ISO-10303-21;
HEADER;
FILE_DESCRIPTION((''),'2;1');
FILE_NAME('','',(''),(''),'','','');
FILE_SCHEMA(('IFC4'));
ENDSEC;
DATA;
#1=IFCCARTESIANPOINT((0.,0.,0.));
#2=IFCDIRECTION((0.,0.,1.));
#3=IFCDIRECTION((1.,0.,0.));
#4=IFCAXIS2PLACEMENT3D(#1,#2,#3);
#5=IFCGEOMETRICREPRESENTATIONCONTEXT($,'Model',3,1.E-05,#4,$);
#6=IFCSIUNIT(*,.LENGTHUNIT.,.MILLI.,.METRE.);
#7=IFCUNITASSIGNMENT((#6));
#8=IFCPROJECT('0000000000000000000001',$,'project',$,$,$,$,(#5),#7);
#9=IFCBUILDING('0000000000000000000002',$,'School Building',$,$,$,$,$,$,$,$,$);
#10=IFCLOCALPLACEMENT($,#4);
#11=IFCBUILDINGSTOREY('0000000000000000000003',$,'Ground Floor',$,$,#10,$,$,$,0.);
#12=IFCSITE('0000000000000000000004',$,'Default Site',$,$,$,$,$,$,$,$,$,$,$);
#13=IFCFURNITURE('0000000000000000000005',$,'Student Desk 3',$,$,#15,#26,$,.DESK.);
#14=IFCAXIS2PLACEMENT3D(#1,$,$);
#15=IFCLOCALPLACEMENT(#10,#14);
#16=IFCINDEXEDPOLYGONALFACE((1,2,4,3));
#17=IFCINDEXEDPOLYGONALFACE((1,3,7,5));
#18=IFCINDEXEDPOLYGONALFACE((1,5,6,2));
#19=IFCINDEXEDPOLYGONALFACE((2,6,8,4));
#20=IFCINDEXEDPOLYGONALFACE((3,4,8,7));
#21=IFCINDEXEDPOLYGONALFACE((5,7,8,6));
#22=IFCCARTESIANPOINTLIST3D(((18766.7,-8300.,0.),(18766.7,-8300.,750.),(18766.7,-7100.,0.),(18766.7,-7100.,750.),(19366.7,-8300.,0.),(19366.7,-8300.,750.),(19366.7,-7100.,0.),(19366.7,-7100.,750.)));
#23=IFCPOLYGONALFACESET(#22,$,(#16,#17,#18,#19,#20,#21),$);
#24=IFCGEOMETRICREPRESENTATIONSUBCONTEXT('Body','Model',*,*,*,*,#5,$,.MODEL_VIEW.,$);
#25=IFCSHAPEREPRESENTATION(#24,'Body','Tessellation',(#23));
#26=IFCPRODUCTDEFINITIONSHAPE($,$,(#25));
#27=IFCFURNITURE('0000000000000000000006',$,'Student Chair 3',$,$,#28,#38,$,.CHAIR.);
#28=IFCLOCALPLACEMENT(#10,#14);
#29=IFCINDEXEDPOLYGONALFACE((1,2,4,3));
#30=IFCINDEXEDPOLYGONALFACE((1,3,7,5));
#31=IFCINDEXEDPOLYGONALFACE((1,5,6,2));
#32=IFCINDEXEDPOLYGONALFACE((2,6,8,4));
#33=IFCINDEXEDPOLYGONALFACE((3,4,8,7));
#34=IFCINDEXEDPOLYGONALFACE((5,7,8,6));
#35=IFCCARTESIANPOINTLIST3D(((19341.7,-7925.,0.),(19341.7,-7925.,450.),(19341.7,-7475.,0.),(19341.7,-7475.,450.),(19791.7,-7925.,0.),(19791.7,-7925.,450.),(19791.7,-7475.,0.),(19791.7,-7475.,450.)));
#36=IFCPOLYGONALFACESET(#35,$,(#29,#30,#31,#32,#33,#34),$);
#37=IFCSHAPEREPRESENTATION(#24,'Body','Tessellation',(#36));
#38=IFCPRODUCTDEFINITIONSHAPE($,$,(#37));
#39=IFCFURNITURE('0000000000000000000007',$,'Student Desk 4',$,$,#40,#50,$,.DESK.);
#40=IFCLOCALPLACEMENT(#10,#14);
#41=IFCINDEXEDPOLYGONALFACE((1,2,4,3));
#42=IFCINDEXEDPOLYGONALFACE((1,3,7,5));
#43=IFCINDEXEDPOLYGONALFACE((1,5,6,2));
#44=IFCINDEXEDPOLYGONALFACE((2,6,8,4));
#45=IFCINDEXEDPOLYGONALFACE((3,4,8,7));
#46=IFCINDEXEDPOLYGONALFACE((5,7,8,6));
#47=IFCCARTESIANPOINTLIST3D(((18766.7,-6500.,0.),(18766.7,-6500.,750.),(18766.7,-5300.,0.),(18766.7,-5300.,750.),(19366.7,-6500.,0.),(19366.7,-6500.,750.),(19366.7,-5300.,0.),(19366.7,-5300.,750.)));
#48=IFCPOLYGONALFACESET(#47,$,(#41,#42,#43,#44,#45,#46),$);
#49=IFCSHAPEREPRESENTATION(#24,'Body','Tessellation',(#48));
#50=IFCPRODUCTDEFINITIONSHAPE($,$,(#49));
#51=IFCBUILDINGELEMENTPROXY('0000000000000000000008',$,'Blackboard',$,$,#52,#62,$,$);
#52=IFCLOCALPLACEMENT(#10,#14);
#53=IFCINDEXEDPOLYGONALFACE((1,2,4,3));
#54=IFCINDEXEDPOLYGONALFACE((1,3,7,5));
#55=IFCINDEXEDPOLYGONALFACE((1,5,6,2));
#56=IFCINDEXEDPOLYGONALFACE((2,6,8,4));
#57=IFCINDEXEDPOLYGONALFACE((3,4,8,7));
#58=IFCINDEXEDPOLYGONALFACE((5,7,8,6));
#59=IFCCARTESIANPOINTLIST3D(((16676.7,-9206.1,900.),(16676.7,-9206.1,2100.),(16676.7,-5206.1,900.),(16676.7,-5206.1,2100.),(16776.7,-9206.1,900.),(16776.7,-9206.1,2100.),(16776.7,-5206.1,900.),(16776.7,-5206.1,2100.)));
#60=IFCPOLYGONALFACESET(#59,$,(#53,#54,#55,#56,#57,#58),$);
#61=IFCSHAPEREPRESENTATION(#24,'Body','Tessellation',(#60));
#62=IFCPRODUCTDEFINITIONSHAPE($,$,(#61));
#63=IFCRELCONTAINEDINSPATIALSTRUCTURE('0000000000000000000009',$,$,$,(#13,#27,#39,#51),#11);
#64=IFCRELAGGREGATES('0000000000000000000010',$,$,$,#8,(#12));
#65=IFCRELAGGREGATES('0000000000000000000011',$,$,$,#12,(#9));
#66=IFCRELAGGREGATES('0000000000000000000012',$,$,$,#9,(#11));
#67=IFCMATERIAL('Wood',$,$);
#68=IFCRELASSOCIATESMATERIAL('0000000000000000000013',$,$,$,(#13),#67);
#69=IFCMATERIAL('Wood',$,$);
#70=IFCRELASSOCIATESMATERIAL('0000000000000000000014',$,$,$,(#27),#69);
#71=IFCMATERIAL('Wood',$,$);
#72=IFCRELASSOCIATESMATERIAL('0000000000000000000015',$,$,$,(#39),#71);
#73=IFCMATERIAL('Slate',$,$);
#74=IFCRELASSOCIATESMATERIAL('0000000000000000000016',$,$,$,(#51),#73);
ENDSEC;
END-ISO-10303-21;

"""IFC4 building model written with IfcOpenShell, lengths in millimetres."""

from ifc_helpers import new_model, si_unit, frame, origin_with_axes, origin_2d, place, context, subcontext, project, spatial, rectangle, extrude, material, element, save


model = new_model("IFC4")

# Units and contexts
model_context = context("Model", 3, precision=1e-05, world=origin_with_axes())
body_context = subcontext(model_context, "Body", "Model", "MODEL_VIEW")
ifc_project = project(units=[si_unit("LENGTHUNIT", "METRE", prefix="MILLI")], contexts=[model_context])

# Site, building, storey
site = spatial("IfcSite", under=ifc_project, Name="Default Site")
building = spatial("IfcBuilding", under=site, Name="School Building")
storey_placement = place(None, origin_with_axes())
storey = spatial("IfcBuildingStorey", under=building, at=storey_placement, Name="Ground Floor", Elevation=0.0)

# Furniture
ifc_material_1 = material(Name="Wood")
furniture_1_placement = place(storey_placement, frame((19066.7, -7700.0, 0.0), z_axis=(0.0, 0.0, 1.0), x_axis=(0.0, 1.0, 0.0)))
element("IfcFurniture", 1, at=furniture_1_placement, inside=storey, material=ifc_material_1, Name="Student Desk 3", PredefinedType="DESK", context=body_context, shape_type="SweptSolid", body=[
    extrude(rectangle(XDim=1200.0, YDim=600.0, at=origin_2d()), origin_with_axes(), (0.0, 0.0, 1.0), 750.0),
])
ifc_material_2 = material(Name="Wood")
furniture_2_placement = place(storey_placement, frame((19566.7, -7700.0, 0.0), z_axis=(0.0, 0.0, 1.0), x_axis=(1.0, 0.0, 0.0)))
element("IfcFurniture", 2, at=furniture_2_placement, inside=storey, material=ifc_material_2, Name="Student Chair 3", PredefinedType="CHAIR", context=body_context, shape_type="SweptSolid", body=[
    extrude(rectangle(XDim=450.0, YDim=450.0, at=origin_2d()), origin_with_axes(), (0.0, 0.0, 1.0), 450.0),
])
ifc_material_3 = material(Name="Wood")
furniture_3_placement = place(storey_placement, frame((19066.7, -5900.0, 0.0), z_axis=(0.0, 0.0, 1.0), x_axis=(0.0, 1.0, 0.0)))
element("IfcFurniture", 3, at=furniture_3_placement, inside=storey, material=ifc_material_3, Name="Student Desk 4", PredefinedType="DESK", context=body_context, shape_type="SweptSolid", body=[
    extrude(rectangle(XDim=1200.0, YDim=600.0, at=origin_2d()), origin_with_axes(), (0.0, 0.0, 1.0), 750.0),
])

# Building element proxy
ifc_material_4 = material(Name="Slate")
proxy_placement = place(storey_placement, frame((16726.7, -7206.1, 900.0), z_axis=(0.0, 0.0, 1.0), x_axis=(1.0, 0.0, 0.0)))
element("IfcBuildingElementProxy", 4, at=proxy_placement, inside=storey, material=ifc_material_4, Name="Blackboard", context=body_context, shape_type="SweptSolid", body=[
    extrude(rectangle(XDim=100.0, YDim=4000.0, at=origin_2d()), origin_with_axes(), (0.0, 0.0, 1.0), 1200.0),
])

save(model, "model.ifc")
